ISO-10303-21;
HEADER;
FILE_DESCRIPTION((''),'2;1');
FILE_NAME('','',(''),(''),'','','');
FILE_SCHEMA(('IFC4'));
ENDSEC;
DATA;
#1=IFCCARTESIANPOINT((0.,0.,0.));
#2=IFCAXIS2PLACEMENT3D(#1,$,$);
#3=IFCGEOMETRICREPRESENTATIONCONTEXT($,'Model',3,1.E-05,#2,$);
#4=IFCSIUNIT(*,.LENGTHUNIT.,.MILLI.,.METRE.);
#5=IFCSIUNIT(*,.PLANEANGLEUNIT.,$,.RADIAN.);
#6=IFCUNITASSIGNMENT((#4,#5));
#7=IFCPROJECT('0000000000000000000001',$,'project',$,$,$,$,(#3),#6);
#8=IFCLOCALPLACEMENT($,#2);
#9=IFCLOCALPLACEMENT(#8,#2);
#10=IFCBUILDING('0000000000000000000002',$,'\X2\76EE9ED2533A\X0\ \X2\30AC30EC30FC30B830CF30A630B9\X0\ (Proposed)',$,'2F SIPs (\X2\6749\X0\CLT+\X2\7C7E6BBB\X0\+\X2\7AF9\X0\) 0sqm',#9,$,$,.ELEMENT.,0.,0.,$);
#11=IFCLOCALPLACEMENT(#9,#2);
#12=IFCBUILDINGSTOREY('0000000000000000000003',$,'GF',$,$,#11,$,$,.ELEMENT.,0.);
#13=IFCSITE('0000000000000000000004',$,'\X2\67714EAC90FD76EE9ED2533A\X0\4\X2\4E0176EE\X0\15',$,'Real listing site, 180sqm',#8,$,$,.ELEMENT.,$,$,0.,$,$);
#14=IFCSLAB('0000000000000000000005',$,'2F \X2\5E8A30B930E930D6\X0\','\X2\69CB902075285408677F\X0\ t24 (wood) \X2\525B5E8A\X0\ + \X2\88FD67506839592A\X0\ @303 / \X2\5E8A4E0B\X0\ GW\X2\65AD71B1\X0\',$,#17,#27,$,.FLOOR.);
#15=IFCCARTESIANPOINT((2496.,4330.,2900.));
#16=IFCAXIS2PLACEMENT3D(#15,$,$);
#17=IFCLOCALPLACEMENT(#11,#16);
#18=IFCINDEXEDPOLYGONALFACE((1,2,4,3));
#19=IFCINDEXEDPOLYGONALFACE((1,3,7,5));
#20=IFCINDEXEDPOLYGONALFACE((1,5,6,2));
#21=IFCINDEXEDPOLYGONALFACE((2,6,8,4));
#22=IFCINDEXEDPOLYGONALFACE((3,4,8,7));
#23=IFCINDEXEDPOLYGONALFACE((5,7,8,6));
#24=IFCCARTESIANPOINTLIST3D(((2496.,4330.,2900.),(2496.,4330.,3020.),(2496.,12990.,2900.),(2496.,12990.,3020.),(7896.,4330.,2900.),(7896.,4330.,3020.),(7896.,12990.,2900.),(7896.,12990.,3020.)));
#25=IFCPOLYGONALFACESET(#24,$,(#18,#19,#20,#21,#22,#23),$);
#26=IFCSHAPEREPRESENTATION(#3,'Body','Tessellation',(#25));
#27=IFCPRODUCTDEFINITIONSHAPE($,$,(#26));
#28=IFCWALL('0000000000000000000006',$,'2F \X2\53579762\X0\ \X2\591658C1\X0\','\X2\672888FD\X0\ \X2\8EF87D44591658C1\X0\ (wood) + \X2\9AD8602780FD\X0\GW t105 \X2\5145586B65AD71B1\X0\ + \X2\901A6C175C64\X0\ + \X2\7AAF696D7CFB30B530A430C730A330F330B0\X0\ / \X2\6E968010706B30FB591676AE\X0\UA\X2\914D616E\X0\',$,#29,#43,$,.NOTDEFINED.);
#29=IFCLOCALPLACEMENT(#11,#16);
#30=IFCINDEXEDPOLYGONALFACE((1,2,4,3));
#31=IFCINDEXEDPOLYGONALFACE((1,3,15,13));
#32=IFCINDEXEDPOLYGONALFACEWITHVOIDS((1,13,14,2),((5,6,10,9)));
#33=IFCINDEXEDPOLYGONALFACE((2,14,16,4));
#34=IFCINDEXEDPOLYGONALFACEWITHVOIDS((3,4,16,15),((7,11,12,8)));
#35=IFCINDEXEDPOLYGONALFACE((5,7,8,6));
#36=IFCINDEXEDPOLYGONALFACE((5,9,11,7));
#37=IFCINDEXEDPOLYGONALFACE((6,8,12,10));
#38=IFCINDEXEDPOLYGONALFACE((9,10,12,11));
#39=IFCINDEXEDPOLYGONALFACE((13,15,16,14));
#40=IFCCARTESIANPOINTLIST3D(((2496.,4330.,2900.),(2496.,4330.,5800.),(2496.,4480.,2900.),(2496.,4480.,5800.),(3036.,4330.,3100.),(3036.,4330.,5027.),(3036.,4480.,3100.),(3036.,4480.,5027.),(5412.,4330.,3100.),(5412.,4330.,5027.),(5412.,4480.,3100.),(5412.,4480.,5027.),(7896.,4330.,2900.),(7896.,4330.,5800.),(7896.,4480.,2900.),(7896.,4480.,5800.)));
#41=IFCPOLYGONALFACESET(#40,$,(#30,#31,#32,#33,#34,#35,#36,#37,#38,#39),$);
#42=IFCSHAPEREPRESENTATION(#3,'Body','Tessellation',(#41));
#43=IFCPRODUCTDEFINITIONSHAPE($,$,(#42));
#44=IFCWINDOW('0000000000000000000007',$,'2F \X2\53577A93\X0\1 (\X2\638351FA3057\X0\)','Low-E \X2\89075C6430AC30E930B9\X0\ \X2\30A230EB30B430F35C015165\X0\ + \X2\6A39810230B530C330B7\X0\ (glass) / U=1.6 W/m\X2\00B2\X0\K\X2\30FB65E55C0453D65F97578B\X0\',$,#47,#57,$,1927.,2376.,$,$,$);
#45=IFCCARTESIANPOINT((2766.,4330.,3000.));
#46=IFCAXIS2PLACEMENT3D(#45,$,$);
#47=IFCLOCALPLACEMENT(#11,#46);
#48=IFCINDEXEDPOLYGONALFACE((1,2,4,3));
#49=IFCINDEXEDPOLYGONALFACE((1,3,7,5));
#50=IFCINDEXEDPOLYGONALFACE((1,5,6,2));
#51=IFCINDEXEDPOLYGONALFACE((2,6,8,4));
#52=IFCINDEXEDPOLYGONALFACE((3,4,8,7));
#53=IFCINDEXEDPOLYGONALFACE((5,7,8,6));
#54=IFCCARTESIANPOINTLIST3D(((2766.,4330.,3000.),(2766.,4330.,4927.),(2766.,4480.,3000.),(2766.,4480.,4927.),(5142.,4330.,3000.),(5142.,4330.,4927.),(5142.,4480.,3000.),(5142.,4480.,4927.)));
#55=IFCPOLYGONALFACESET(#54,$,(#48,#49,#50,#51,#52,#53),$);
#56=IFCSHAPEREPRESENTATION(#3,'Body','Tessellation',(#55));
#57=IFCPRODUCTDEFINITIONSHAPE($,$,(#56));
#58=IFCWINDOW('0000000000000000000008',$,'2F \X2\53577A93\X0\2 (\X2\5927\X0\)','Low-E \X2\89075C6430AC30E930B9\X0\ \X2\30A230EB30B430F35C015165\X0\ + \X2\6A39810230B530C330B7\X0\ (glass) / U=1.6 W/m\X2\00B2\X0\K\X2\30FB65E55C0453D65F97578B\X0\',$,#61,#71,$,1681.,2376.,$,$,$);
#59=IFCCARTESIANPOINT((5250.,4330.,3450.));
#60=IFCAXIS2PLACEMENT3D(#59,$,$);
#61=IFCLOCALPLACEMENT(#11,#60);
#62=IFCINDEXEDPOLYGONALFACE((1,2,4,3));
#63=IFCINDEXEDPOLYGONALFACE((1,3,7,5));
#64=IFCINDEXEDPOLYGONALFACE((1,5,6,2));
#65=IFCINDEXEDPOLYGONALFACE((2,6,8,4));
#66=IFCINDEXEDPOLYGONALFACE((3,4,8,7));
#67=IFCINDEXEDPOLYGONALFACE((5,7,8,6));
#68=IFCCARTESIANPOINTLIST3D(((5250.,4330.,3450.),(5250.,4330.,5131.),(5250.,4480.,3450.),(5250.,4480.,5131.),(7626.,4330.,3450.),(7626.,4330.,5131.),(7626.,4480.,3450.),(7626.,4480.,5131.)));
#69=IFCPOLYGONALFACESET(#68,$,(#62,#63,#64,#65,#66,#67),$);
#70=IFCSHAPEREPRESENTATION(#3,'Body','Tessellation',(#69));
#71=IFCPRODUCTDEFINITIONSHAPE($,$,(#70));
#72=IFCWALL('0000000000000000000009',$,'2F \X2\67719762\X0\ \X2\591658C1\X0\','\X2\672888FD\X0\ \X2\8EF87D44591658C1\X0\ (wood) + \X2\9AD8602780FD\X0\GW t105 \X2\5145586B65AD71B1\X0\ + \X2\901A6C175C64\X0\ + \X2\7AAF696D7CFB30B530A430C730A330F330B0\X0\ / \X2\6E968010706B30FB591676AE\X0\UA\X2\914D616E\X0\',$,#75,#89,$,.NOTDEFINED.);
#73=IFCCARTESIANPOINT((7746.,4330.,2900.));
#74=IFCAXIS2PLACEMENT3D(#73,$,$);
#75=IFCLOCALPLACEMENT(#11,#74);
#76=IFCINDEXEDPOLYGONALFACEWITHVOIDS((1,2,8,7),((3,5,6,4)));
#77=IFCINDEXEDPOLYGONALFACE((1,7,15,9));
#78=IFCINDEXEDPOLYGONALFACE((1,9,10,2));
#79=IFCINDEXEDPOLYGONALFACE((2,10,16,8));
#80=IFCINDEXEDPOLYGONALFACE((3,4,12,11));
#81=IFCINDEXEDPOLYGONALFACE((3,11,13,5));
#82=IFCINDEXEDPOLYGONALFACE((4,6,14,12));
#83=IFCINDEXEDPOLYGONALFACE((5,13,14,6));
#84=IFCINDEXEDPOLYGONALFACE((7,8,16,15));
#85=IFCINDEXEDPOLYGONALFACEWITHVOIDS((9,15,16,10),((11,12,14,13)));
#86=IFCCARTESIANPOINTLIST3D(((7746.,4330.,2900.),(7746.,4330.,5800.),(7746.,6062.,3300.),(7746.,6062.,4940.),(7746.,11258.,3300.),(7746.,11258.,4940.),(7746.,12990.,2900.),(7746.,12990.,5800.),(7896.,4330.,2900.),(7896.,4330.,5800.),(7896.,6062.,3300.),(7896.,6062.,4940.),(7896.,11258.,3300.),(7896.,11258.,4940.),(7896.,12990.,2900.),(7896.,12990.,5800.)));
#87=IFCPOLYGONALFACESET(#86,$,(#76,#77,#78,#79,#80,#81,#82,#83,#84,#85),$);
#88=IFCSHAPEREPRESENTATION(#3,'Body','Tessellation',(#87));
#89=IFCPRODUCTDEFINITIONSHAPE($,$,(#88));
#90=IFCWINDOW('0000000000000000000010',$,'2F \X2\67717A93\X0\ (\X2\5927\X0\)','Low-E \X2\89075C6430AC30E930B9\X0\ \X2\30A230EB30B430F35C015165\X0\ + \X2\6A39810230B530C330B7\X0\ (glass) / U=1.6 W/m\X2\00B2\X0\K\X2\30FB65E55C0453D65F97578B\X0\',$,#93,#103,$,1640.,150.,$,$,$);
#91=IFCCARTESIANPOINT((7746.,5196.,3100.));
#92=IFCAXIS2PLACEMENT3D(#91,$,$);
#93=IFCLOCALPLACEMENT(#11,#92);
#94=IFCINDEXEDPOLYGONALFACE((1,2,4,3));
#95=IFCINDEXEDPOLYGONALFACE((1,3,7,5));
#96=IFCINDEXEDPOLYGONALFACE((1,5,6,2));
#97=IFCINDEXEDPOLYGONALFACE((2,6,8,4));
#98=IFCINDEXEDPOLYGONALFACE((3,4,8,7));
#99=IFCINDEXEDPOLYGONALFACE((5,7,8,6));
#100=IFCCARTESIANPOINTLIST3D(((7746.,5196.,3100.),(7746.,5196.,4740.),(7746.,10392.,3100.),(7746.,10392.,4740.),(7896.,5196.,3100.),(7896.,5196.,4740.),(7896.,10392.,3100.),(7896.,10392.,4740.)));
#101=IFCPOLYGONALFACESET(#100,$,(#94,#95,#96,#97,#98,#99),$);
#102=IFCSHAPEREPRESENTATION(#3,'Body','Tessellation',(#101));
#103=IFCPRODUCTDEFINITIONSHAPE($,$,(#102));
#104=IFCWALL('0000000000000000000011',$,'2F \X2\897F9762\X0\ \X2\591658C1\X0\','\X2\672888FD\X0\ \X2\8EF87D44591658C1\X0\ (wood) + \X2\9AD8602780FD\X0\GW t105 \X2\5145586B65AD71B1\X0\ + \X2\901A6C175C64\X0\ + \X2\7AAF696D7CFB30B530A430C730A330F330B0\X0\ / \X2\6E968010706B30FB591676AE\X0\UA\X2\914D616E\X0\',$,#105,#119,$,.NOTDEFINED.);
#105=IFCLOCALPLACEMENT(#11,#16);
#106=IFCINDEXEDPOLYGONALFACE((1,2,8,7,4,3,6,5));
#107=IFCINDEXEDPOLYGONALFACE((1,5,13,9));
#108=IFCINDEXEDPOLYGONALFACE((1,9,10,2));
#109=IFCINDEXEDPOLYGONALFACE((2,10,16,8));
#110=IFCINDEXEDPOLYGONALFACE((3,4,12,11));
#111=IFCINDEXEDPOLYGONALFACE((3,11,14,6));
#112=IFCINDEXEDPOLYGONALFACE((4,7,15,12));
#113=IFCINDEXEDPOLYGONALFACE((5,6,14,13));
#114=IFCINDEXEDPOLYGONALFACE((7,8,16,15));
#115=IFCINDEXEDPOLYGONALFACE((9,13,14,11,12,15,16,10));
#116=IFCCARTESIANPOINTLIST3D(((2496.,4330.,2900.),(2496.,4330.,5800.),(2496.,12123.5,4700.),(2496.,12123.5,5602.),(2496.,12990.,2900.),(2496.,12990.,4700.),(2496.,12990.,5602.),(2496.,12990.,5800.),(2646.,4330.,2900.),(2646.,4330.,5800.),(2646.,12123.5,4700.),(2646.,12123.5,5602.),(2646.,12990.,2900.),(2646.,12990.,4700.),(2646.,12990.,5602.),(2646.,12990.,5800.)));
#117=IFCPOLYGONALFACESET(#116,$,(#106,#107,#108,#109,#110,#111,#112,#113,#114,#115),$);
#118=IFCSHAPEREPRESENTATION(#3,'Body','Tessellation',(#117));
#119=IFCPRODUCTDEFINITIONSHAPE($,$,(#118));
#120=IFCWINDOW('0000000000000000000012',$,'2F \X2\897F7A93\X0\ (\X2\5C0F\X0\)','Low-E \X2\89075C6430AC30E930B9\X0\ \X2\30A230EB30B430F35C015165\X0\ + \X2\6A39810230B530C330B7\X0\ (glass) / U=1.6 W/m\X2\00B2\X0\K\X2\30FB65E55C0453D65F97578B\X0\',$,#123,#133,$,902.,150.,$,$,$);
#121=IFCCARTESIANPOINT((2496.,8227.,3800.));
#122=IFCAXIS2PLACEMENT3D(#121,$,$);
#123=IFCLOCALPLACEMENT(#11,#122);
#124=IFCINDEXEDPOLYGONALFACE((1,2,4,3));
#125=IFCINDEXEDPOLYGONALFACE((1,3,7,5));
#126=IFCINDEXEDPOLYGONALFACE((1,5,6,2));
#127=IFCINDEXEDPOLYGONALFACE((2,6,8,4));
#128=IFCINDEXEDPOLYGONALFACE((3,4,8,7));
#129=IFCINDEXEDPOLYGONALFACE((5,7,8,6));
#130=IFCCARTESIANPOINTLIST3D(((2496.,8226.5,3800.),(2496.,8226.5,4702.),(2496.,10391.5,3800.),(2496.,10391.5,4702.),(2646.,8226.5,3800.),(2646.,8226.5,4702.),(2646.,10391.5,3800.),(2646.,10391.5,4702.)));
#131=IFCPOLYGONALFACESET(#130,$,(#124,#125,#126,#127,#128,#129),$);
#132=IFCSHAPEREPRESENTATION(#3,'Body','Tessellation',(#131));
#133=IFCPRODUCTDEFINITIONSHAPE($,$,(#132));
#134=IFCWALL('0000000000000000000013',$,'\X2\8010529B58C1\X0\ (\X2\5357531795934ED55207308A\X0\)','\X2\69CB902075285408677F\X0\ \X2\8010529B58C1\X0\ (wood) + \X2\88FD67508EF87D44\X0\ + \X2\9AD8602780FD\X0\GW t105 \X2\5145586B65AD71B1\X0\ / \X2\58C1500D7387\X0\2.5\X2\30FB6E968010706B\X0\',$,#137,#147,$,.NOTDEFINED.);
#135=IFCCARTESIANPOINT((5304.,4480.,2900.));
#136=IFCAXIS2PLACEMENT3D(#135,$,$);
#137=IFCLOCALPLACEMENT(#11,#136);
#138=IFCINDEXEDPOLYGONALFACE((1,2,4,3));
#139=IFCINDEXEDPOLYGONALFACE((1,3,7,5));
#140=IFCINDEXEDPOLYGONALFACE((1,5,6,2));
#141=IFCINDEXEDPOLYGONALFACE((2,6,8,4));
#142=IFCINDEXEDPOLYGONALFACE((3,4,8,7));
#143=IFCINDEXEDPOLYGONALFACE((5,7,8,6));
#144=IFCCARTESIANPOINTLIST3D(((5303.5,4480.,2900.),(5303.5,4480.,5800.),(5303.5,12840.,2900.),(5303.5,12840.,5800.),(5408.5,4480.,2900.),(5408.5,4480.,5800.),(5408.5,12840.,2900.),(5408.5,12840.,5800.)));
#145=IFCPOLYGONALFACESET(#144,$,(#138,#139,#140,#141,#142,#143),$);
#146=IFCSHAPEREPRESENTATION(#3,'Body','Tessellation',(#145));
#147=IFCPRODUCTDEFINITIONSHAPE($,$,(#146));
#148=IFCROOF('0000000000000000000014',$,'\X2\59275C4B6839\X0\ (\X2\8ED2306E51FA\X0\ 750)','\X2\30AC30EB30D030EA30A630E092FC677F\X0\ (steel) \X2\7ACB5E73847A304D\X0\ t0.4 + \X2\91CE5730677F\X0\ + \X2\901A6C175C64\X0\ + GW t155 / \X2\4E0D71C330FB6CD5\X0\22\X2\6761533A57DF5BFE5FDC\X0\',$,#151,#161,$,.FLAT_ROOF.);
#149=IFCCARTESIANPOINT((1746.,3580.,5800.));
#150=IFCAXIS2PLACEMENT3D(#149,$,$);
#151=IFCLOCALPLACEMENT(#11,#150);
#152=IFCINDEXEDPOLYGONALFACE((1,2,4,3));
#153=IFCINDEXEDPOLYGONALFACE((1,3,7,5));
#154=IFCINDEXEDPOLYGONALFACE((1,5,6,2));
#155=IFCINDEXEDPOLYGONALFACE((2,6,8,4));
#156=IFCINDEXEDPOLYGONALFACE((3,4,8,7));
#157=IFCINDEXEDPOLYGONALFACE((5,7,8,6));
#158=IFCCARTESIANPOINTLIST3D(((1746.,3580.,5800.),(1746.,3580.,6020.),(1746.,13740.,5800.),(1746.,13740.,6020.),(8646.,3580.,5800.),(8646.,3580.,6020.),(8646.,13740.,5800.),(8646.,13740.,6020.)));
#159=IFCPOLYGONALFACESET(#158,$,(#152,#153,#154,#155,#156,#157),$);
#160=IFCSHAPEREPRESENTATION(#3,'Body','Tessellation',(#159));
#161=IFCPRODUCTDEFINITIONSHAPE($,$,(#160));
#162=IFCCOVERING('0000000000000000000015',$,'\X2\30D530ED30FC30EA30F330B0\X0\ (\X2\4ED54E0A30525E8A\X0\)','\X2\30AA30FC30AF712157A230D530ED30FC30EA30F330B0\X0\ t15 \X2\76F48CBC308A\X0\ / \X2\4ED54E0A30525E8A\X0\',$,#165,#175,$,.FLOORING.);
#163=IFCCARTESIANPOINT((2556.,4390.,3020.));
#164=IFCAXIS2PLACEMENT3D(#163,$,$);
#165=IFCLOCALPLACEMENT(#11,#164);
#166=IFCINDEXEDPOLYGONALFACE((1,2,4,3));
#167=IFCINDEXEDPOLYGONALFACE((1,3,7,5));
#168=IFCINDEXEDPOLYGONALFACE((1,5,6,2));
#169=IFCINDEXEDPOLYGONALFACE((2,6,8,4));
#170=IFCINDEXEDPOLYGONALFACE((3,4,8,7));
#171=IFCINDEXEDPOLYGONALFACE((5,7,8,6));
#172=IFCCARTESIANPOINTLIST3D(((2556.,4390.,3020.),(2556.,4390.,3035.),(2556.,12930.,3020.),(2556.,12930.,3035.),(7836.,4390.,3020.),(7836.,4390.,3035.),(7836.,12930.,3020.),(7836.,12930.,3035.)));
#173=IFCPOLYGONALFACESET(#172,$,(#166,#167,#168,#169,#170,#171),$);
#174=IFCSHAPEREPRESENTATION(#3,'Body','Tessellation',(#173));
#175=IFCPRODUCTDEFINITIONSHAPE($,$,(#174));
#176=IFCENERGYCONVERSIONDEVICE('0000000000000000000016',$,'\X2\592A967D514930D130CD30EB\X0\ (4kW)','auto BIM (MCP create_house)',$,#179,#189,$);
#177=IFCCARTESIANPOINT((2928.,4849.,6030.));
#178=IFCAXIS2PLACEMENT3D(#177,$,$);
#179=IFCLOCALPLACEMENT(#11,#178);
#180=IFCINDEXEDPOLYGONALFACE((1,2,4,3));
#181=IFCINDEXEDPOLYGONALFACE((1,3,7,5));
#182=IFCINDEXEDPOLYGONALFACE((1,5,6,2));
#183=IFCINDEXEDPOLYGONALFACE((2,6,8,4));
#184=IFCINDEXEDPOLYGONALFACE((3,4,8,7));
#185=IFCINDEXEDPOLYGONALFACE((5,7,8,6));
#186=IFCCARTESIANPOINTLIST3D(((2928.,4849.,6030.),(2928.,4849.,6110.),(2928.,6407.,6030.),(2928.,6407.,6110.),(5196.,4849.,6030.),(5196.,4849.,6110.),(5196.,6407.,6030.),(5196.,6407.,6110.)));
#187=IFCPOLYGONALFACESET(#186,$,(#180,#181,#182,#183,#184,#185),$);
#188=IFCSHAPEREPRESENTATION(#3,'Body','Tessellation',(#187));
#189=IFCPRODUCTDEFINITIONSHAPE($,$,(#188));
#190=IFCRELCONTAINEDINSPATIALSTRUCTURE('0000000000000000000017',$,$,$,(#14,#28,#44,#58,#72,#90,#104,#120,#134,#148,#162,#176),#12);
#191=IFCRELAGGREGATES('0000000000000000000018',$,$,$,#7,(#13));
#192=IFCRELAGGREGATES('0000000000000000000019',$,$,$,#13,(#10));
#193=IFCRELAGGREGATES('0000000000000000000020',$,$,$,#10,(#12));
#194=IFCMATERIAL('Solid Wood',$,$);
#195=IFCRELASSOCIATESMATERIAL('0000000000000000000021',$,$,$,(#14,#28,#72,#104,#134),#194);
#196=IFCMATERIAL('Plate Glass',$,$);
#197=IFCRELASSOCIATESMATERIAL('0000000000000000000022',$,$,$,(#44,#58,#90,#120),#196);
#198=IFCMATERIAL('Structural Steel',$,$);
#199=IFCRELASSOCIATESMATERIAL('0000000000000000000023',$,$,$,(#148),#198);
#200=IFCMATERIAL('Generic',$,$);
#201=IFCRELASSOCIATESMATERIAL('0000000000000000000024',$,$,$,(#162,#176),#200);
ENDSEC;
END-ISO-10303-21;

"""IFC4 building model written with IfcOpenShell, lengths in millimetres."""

from ifc_helpers import new_model, si_unit, frame, frame_2d, origin, place, context, project, spatial, rectangle, extrude, material, element, fill, save


model = new_model("IFC4")

# Units and contexts
model_context = context("Model", 3, precision=1e-05, world=origin())
ifc_project = project(units=[si_unit("LENGTHUNIT", "METRE", prefix="MILLI"), si_unit("PLANEANGLEUNIT", "RADIAN")], contexts=[model_context])

# Site, building, storey
site_placement = place(None, origin())
site = spatial("IfcSite", under=ifc_project, at=site_placement, Name="東京都目黒区4丁目15", ObjectType="Real listing site, 180sqm", CompositionType="ELEMENT", RefElevation=0.0)
building_placement = place(site_placement, origin())
building = spatial("IfcBuilding", under=site, at=building_placement, Name="目黒区 ガレージハウス (Proposed)", ObjectType="2F SIPs (杉CLT+籾殻+竹) 0sqm", CompositionType="ELEMENT", ElevationOfRefHeight=0.0, ElevationOfTerrain=0.0)
storey_placement = place(building_placement, origin())
storey = spatial("IfcBuildingStorey", under=building, at=storey_placement, Name="GF", CompositionType="ELEMENT", Elevation=0.0)

# Slab
ifc_material_1 = material(Name="Solid Wood")
slab_placement = place(storey_placement, frame((2496.0, 4330.0, 2900.0)))
element("IfcSlab", 1, at=slab_placement, inside=storey, material=ifc_material_1, Name="2F 床スラブ", Description="構造用合板 t24 (wood) 剛床 + 製材根太 @303 / 床下 GW断熱", PredefinedType="FLOOR", context=model_context, shape_type="SweptSolid", body=[
    extrude(rectangle(XDim=5400.0, YDim=8660.0, at=frame_2d((2700.0, 4330.0))), frame((2496.0, 4330.0, 2900.0)), (0.0, 0.0, 1.0), 120.0),
])

# Wall, openings, windows
wall_1_placement = place(storey_placement, frame((2496.0, 4330.0, 2900.0)))
wall_1 = element("IfcWall", 2, at=wall_1_placement, inside=storey, material=ifc_material_1, Name="2F 南面 外壁", Description="木製 軸組外壁 (wood) + 高性能GW t105 充填断熱 + 通気層 + 窯業系サイディング / 準耐火・外皮UA配慮", PredefinedType="NOTDEFINED", context=model_context, shape_type="SweptSolid", body=[
    extrude(rectangle(XDim=5400.0, YDim=150.0, at=frame_2d((2700.0, 75.0))), frame((2496.0, 4330.0, 2900.0)), (0.0, 0.0, 1.0), 2900.0),
])
opening_1_placement = place(storey_placement, frame((2766.0, 4330.0, 3000.0)))
opening_1 = element("IfcOpeningElement", 3, at=opening_1_placement, cuts=wall_1, PredefinedType="NOTDEFINED", context=model_context, shape_type="SweptSolid", body=[
    extrude(rectangle(XDim=2376.0, YDim=150.0, at=frame_2d((1188.0, 75.0))), frame((2766.0, 4330.0, 3000.0)), (0.0, 0.0, 1.0), 1927.0),
])
opening_2_placement = place(storey_placement, frame((5250.0, 4330.0, 3450.0)))
opening_2 = element("IfcOpeningElement", 4, at=opening_2_placement, cuts=wall_1, PredefinedType="NOTDEFINED", context=model_context, shape_type="SweptSolid", body=[
    extrude(rectangle(XDim=2376.0, YDim=150.0, at=frame_2d((1188.0, 75.0))), frame((5250.0, 4330.0, 3450.0)), (0.0, 0.0, 1.0), 1681.0),
])
ifc_material_2 = material(Name="Plate Glass")
window_1_placement = place(storey_placement, frame((2766.0, 4330.0, 3000.0)))
window_1 = element("IfcWindow", 5, at=window_1_placement, inside=storey, material=ifc_material_2, Name="2F 南窓1 (掃出し)", Description="Low-E 複層ガラス アルゴン封入 + 樹脂サッシ (glass) / U=1.6 W/m²K・日射取得型", OverallHeight=1927.0, OverallWidth=2376.0, context=model_context, shape_type="SweptSolid", body=[
    extrude(rectangle(XDim=2376.0, YDim=150.0, at=frame_2d((1188.0, 75.0))), frame((2766.0, 4330.0, 3000.0)), (0.0, 0.0, 1.0), 1927.0),
])
fill(opening_1, window_1)
window_2_placement = place(storey_placement, frame((5250.0, 4330.0, 3450.0)))
window_2 = element("IfcWindow", 6, at=window_2_placement, inside=storey, material=ifc_material_2, Name="2F 南窓2 (大)", Description="Low-E 複層ガラス アルゴン封入 + 樹脂サッシ (glass) / U=1.6 W/m²K・日射取得型", OverallHeight=1681.0, OverallWidth=2376.0, context=model_context, shape_type="SweptSolid", body=[
    extrude(rectangle(XDim=2376.0, YDim=150.0, at=frame_2d((1188.0, 75.0))), frame((5250.0, 4330.0, 3450.0)), (0.0, 0.0, 1.0), 1681.0),
])
fill(opening_2, window_2)

# Walls, openings, windows
wall_2_placement = place(storey_placement, frame((7746.0, 4330.0, 2900.0)))
wall_2 = element("IfcWall", 7, at=wall_2_placement, inside=storey, material=ifc_material_1, Name="2F 東面 外壁", Description="木製 軸組外壁 (wood) + 高性能GW t105 充填断熱 + 通気層 + 窯業系サイディング / 準耐火・外皮UA配慮", PredefinedType="NOTDEFINED", context=model_context, shape_type="SweptSolid", body=[
    extrude(rectangle(XDim=150.0, YDim=8660.0, at=frame_2d((75.0, 4330.0))), frame((7746.0, 4330.0, 2900.0)), (0.0, 0.0, 1.0), 2900.0),
])
opening_3_placement = place(storey_placement, frame((7746.0, 5196.0, 3100.0)))
opening_3 = element("IfcOpeningElement", 8, at=opening_3_placement, cuts=wall_2, PredefinedType="NOTDEFINED", context=model_context, shape_type="SweptSolid", body=[
    extrude(rectangle(XDim=150.0, YDim=5196.0, at=frame_2d((75.0, 2598.0))), frame((7746.0, 5196.0, 3100.0)), (0.0, 0.0, 1.0), 1640.0),
])
window_3_placement = place(storey_placement, frame((7746.0, 5196.0, 3100.0)))
window_3 = element("IfcWindow", 9, at=window_3_placement, inside=storey, material=ifc_material_2, Name="2F 東窓 (大)", Description="Low-E 複層ガラス アルゴン封入 + 樹脂サッシ (glass) / U=1.6 W/m²K・日射取得型", OverallHeight=1640.0, OverallWidth=150.0, context=model_context, shape_type="SweptSolid", body=[
    extrude(rectangle(XDim=150.0, YDim=5196.0, at=frame_2d((75.0, 2598.0))), frame((7746.0, 5196.0, 3100.0)), (0.0, 0.0, 1.0), 1640.0),
])
fill(opening_3, window_3)
wall_3_placement = place(storey_placement, frame((2496.0, 4330.0, 2900.0)))
wall_3 = element("IfcWall", 10, at=wall_3_placement, inside=storey, material=ifc_material_1, Name="2F 西面 外壁", Description="木製 軸組外壁 (wood) + 高性能GW t105 充填断熱 + 通気層 + 窯業系サイディング / 準耐火・外皮UA配慮", PredefinedType="NOTDEFINED", context=model_context, shape_type="SweptSolid", body=[
    extrude(rectangle(XDim=150.0, YDim=8660.0, at=frame_2d((75.0, 4330.0))), frame((2496.0, 4330.0, 2900.0)), (0.0, 0.0, 1.0), 2900.0),
])
opening_4_placement = place(storey_placement, frame((2496.0, 8227.0, 3800.0)))
opening_4 = element("IfcOpeningElement", 11, at=opening_4_placement, cuts=wall_3, PredefinedType="NOTDEFINED", context=model_context, shape_type="SweptSolid", body=[
    extrude(rectangle(XDim=150.0, YDim=2165.0, at=frame_2d((75.0, 1082.0))), frame((2496.0, 8227.0, 3800.0)), (0.0, 0.0, 1.0), 902.0),
])
window_4_placement = place(storey_placement, frame((2496.0, 8227.0, 3800.0)))
window_4 = element("IfcWindow", 12, at=window_4_placement, inside=storey, material=ifc_material_2, Name="2F 西窓 (小)", Description="Low-E 複層ガラス アルゴン封入 + 樹脂サッシ (glass) / U=1.6 W/m²K・日射取得型", OverallHeight=902.0, OverallWidth=150.0, context=model_context, shape_type="SweptSolid", body=[
    extrude(rectangle(XDim=150.0, YDim=2165.0, at=frame_2d((75.0, 1082.0))), frame((2496.0, 8227.0, 3800.0)), (0.0, 0.0, 1.0), 902.0),
])
fill(opening_4, window_4)

# Wall
wall_4_placement = place(storey_placement, frame((5304.0, 4480.0, 2900.0)))
element("IfcWall", 13, at=wall_4_placement, inside=storey, material=ifc_material_1, Name="耐力壁 (南北間仕切り)", Description="構造用合板 耐力壁 (wood) + 製材軸組 + 高性能GW t105 充填断熱 / 壁倍率2.5・準耐火", PredefinedType="NOTDEFINED", context=model_context, shape_type="SweptSolid", body=[
    extrude(rectangle(XDim=105.0, YDim=8360.0, at=frame_2d((52.0, 4180.0))), frame((5304.0, 4480.0, 2900.0)), (0.0, 0.0, 1.0), 2900.0),
])

# Roof
ifc_material_3 = material(Name="Structural Steel")
roof_placement = place(storey_placement, frame((1746.0, 3580.0, 5800.0)))
element("IfcRoof", 14, at=roof_placement, inside=storey, material=ifc_material_3, Name="大屋根 (軒の出 750)", Description="ガルバリウム鋼板 (steel) 立平葺き t0.4 + 野地板 + 通気層 + GW t155 / 不燃・法22条区域対応", PredefinedType="FLAT_ROOF", context=model_context, shape_type="SweptSolid", body=[
    extrude(rectangle(XDim=6900.0, YDim=10160.0, at=frame_2d((3450.0, 5080.0))), frame((1746.0, 3580.0, 5800.0)), (0.0, 0.0, 1.0), 220.0),
])

# Covering
ifc_material_4 = material(Name="Generic")
covering_placement = place(storey_placement, frame((2556.0, 4390.0, 3020.0)))
element("IfcCovering", 15, at=covering_placement, inside=storey, material=ifc_material_4, Name="フローリング (仕上げ床)", Description="オーク無垢フローリング t15 直貼り / 仕上げ床", PredefinedType="FLOORING", context=model_context, shape_type="SweptSolid", body=[
    extrude(rectangle(XDim=5280.0, YDim=8540.0, at=frame_2d((2640.0, 4270.0))), frame((2556.0, 4390.0, 3020.0)), (0.0, 0.0, 1.0), 15.0),
])

# Energy conversion device
energy_conversion_device_placement = place(storey_placement, frame((2928.0, 4849.0, 6030.0)))
element("IfcEnergyConversionDevice", 16, at=energy_conversion_device_placement, inside=storey, material=ifc_material_4, Name="太陽光パネル (4kW)", Description="auto BIM (MCP create_house)", context=model_context, shape_type="SweptSolid", body=[
    extrude(rectangle(XDim=2268.0, YDim=1558.0, at=frame_2d((1134.0, 779.0))), frame((2928.0, 4849.0, 6030.0)), (0.0, 0.0, 1.0), 80.0),
])

save(model, "model.ifc")
